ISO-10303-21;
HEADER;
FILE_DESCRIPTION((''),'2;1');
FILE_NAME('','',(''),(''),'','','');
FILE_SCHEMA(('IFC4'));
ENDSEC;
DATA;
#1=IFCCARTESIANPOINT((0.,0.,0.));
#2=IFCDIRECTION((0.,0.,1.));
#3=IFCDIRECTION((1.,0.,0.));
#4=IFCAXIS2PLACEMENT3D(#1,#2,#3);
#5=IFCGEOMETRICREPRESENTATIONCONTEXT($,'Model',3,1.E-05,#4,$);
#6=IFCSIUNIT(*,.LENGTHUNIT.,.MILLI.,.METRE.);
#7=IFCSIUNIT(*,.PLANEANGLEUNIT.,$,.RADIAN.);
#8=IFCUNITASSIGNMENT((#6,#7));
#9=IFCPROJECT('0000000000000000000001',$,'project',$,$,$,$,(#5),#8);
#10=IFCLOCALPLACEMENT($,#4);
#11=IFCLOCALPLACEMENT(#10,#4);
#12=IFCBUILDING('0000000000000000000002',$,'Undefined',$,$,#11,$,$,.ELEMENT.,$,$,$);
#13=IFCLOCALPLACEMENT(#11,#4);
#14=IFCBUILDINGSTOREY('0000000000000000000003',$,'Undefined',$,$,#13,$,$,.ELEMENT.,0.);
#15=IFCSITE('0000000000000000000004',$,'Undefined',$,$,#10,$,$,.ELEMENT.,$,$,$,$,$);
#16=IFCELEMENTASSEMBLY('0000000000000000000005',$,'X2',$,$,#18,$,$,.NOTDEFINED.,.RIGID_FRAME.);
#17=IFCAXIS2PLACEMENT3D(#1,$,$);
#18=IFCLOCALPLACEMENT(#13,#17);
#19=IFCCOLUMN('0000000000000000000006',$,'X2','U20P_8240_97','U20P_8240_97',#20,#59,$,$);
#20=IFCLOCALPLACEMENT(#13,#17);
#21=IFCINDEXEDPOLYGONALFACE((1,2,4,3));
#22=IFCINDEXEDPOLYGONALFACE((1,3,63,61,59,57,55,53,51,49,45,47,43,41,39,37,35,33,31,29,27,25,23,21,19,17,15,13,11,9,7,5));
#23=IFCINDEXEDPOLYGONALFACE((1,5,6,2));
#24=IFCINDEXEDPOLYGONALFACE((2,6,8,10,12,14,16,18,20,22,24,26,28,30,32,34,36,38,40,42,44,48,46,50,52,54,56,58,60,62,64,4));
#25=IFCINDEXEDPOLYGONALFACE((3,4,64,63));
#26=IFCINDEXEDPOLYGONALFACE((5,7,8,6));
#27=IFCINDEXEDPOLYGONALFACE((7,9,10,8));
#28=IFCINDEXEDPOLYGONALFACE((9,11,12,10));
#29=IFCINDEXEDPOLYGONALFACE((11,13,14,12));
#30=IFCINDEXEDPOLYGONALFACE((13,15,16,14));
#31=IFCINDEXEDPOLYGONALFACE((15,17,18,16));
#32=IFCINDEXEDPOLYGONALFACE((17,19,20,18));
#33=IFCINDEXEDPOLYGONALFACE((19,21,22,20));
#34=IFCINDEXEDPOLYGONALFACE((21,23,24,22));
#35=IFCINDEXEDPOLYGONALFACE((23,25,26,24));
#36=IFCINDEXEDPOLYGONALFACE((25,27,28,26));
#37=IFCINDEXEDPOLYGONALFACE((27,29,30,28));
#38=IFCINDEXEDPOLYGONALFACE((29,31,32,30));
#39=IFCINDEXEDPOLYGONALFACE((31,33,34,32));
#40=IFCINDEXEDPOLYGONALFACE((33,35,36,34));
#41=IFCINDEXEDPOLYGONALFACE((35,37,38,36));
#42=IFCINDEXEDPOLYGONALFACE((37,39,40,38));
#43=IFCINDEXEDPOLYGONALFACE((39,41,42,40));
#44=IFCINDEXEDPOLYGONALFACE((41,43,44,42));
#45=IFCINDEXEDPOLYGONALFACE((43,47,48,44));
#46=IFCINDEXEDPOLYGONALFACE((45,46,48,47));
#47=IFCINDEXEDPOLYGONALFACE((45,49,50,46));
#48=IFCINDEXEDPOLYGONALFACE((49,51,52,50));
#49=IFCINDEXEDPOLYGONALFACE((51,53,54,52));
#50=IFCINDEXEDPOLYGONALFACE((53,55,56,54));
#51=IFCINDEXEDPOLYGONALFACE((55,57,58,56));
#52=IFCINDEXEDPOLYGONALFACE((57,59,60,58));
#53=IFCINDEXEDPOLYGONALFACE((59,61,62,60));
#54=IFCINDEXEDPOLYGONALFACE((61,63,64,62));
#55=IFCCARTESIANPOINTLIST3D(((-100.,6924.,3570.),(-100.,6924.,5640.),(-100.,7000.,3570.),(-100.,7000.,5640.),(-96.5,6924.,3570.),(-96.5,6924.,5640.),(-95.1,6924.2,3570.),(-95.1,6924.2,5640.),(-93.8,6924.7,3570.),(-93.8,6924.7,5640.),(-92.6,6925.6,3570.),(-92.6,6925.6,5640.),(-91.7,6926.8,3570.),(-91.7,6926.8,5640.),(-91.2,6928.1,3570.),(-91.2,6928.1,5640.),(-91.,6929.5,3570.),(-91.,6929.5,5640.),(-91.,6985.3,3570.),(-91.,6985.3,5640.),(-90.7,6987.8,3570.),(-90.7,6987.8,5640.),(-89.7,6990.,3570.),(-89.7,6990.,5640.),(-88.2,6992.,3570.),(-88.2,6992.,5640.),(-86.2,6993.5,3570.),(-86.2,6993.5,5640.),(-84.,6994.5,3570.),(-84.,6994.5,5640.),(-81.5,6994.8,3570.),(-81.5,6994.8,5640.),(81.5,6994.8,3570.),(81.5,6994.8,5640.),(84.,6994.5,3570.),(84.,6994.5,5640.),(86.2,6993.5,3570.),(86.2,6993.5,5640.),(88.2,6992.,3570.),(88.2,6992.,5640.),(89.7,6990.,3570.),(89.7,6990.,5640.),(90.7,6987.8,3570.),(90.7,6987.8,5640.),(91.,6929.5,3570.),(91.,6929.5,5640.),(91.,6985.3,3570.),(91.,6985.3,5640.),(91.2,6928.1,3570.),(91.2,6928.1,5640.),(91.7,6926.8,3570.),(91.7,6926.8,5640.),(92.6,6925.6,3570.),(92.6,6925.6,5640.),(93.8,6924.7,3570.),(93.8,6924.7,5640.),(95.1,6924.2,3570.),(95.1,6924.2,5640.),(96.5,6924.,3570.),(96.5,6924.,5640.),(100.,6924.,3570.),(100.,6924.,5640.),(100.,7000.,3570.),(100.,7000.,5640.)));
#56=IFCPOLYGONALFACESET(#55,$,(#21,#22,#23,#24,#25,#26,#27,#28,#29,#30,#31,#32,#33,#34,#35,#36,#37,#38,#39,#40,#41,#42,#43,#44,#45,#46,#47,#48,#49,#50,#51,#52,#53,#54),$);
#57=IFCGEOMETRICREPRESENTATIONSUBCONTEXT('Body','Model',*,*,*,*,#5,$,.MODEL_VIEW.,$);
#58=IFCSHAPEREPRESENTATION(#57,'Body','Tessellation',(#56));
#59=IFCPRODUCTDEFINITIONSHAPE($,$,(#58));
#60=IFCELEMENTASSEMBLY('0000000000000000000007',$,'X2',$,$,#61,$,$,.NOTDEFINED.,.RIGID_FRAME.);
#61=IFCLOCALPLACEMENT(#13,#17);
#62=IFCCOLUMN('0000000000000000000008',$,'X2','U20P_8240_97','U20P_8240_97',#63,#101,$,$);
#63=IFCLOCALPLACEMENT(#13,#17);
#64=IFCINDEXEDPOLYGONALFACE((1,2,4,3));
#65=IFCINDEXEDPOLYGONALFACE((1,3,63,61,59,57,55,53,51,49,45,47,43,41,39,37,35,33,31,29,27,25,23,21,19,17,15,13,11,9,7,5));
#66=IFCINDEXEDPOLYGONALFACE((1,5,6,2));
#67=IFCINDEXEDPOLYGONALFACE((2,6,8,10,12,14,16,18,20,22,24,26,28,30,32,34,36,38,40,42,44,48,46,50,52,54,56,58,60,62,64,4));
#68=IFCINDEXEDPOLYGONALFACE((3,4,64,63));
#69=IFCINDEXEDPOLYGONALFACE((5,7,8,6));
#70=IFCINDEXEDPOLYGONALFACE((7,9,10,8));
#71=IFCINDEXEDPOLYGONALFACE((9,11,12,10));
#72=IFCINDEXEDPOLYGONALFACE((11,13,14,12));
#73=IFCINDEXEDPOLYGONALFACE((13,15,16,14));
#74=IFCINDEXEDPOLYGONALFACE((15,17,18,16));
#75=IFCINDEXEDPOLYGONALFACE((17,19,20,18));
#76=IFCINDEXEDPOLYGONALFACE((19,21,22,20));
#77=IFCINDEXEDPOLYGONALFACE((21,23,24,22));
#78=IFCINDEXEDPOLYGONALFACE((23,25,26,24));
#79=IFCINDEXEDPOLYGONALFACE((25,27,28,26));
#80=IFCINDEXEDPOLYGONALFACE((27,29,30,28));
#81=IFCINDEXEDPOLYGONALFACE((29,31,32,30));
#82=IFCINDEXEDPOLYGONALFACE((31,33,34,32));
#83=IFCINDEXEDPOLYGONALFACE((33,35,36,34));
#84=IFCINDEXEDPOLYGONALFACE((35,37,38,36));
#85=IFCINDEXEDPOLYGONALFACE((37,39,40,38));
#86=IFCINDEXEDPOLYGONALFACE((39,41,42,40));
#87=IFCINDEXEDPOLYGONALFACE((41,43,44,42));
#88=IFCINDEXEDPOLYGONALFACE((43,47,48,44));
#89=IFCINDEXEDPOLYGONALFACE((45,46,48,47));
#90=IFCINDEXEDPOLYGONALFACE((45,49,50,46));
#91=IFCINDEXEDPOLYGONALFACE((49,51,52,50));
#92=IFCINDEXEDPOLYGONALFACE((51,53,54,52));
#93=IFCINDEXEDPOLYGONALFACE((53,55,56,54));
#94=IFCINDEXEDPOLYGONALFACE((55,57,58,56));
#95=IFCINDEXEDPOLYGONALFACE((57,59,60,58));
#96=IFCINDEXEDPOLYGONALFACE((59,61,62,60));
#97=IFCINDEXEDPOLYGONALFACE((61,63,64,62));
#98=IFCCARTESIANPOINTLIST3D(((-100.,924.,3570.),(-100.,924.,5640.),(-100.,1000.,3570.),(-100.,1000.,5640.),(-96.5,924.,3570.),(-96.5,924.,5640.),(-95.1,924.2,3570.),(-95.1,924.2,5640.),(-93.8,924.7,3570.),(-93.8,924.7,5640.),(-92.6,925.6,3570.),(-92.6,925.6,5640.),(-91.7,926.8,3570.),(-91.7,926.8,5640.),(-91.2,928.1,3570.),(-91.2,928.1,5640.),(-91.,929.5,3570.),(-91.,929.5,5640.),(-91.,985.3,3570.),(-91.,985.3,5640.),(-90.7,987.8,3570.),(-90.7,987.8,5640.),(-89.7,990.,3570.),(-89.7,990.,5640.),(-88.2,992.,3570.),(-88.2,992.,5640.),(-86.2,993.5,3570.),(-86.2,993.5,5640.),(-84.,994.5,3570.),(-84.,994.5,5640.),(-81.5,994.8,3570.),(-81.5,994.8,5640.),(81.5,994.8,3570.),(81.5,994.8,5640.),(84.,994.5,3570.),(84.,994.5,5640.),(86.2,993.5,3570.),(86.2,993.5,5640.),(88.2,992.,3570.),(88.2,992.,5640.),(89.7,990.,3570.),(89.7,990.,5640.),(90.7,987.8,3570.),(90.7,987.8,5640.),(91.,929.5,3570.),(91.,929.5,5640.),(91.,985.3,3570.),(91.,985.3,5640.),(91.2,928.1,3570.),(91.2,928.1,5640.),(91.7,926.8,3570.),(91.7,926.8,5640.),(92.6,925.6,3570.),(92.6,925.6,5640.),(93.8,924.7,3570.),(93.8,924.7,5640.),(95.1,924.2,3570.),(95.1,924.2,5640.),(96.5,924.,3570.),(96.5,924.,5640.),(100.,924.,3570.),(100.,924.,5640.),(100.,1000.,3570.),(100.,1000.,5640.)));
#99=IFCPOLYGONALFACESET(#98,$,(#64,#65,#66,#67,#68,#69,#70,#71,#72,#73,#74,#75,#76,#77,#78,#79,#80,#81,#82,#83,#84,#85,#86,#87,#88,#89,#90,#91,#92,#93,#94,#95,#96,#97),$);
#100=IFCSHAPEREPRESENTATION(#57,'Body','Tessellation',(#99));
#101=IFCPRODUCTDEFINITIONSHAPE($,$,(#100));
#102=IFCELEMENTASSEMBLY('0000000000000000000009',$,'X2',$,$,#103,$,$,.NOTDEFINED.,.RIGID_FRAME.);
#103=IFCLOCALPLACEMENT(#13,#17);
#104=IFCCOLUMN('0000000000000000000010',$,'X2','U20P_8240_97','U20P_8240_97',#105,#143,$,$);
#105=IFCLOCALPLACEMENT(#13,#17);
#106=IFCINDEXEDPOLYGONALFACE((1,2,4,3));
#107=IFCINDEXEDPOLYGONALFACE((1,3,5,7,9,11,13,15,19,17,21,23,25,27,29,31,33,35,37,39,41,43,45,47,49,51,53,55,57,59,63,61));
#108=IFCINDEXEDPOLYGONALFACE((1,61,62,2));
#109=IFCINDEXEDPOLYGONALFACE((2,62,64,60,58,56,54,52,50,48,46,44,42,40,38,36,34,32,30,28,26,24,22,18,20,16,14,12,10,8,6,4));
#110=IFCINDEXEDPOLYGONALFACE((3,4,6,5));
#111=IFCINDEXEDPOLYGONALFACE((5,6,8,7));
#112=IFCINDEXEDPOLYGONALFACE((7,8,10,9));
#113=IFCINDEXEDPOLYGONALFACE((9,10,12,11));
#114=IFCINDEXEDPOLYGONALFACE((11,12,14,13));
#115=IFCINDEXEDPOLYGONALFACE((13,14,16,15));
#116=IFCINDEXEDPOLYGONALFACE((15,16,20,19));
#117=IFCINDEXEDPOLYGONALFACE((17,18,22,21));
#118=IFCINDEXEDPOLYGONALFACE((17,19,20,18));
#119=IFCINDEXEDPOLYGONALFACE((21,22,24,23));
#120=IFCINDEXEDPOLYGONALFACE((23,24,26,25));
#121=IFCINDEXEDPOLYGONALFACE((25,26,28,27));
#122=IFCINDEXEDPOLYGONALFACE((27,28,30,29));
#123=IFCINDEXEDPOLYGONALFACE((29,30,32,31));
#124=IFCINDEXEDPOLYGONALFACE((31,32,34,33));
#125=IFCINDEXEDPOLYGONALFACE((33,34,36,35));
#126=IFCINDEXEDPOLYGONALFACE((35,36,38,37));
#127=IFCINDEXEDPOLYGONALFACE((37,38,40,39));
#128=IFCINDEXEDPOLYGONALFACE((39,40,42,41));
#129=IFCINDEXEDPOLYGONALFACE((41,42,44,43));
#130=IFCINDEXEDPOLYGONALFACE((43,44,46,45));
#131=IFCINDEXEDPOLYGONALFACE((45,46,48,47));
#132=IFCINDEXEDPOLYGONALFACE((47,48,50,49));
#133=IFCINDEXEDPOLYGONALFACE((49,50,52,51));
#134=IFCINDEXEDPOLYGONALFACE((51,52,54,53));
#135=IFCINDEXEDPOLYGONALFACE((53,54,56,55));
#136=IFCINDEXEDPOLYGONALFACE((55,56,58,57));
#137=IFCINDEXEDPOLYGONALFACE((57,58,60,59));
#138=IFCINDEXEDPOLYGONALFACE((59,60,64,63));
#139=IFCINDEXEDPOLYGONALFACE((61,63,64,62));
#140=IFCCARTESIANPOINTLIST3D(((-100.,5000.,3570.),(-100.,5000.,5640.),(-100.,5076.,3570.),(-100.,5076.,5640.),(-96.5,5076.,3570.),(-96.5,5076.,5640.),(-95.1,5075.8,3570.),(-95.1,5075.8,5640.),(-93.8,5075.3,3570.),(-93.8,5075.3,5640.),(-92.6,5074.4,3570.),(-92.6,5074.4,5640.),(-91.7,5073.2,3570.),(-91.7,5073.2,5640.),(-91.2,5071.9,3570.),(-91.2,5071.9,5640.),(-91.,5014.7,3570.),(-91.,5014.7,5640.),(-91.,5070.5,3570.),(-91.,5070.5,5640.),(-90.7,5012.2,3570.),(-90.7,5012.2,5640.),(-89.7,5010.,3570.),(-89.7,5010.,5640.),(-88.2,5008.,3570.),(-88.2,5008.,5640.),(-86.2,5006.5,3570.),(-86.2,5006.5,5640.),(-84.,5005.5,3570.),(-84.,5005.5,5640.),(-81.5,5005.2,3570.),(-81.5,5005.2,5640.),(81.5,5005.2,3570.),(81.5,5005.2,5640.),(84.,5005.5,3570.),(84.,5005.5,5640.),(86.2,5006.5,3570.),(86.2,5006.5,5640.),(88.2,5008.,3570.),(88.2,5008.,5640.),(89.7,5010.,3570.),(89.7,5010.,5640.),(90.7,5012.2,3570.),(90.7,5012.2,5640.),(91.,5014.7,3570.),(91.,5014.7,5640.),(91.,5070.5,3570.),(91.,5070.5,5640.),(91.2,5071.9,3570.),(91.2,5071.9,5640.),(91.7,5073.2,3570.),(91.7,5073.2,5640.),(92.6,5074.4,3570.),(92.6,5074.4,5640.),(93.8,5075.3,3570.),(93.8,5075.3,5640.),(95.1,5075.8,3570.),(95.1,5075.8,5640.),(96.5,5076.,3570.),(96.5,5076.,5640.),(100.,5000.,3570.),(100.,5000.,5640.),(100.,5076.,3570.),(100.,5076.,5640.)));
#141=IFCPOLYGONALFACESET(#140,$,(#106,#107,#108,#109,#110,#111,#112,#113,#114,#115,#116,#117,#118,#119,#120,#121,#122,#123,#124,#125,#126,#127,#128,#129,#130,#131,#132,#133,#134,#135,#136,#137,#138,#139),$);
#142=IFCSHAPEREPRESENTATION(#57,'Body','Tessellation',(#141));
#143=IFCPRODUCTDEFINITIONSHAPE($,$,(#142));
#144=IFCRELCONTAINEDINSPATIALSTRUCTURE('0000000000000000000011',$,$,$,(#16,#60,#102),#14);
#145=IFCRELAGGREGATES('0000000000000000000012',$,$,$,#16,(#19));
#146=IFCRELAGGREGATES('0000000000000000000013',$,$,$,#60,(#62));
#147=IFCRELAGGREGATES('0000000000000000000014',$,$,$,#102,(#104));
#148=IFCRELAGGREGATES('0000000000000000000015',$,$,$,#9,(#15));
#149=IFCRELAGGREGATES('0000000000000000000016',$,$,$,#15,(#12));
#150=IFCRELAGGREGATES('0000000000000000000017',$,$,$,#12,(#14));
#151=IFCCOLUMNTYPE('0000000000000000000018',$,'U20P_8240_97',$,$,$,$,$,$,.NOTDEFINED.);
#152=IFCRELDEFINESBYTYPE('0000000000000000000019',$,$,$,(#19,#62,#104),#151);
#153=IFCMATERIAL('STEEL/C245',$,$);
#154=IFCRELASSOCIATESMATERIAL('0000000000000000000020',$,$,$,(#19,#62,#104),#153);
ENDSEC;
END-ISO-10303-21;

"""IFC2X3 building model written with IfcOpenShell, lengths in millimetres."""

from ifc_helpers import new_model, si_unit, frame, origin_with_axes, origin_2d_with_axis, place, context, subcontext, project, spatial, u_section, extrude, material, type_object, element, aggregate, save


model = new_model("IFC2X3")

# Units and contexts
model_context = context("Model", 3, precision=1e-05, world=origin_with_axes())
body_context = subcontext(model_context, "Body", "Model", "MODEL_VIEW")
ifc_project = project(units=[si_unit("LENGTHUNIT", "METRE", prefix="MILLI"), si_unit("PLANEANGLEUNIT", "RADIAN")], contexts=[model_context])

# Site, building, storey
site_placement = place(None, origin_with_axes())
site = spatial("IfcSite", under=ifc_project, at=site_placement, Name="Undefined", CompositionType="ELEMENT")
building_placement = place(site_placement, origin_with_axes())
building = spatial("IfcBuilding", under=site, at=building_placement, Name="Undefined", CompositionType="ELEMENT")
storey_placement = place(building_placement, origin_with_axes())
storey = spatial("IfcBuildingStorey", under=building, at=storey_placement, Name="Undefined", CompositionType="ELEMENT", Elevation=0.0)

# Element assemblies, columns
assembly_1_placement = place(storey_placement, origin_with_axes())
assembly_1 = element("IfcElementAssembly", 1, at=assembly_1_placement, inside=storey, Name="X2", AssemblyPlace="NOTDEFINED", PredefinedType="RIGID_FRAME")
ifc_material_1 = material(Name="STEEL/C245")
column_type = type_object("IfcColumnType", Name="U20P_8240_97", PredefinedType="NOTDEFINED")
column_1_placement = place(assembly_1_placement, frame((0.0, 6962.0, 3570.0), z_axis=(0.0, 0.0, 1.0), x_axis=(-1.0, 0.0, 0.0)))
column_1 = element("IfcColumn", 2, at=column_1_placement, type_object=column_type, material=ifc_material_1, Name="X2", Description="U20P_8240_97", ObjectType="U20P_8240_97", context=body_context, shape_type="SweptSolid", body=[
    extrude(u_section(Depth=200.0, FlangeWidth=76.0, WebThickness=5.2, FlangeThickness=9.0, FilletRadius=9.5, EdgeRadius=5.5, at=origin_2d_with_axis()), frame((0.0, 0.0, 2070.0), z_axis=(0.0, 0.0, -1.0), x_axis=(0.0, 1.0, 0.0)), (0.0, 0.0, 1.0), 2070.0),
])
aggregate(assembly_1, [column_1])
assembly_2_placement = place(storey_placement, origin_with_axes())
assembly_2 = element("IfcElementAssembly", 3, at=assembly_2_placement, inside=storey, Name="X2", AssemblyPlace="NOTDEFINED", PredefinedType="RIGID_FRAME")
column_2_placement = place(assembly_2_placement, frame((0.0, 962.0, 3570.0), z_axis=(0.0, 0.0, 1.0), x_axis=(-1.0, 0.0, 0.0)))
column_2 = element("IfcColumn", 4, at=column_2_placement, type_object=column_type, material=ifc_material_1, Name="X2", Description="U20P_8240_97", ObjectType="U20P_8240_97", context=body_context, shape_type="SweptSolid", body=[
    extrude(u_section(Depth=200.0, FlangeWidth=76.0, WebThickness=5.2, FlangeThickness=9.0, FilletRadius=9.5, EdgeRadius=5.5, at=origin_2d_with_axis()), frame((0.0, 0.0, 2070.0), z_axis=(0.0, 0.0, -1.0), x_axis=(0.0, 1.0, 0.0)), (0.0, 0.0, 1.0), 2070.0),
])
aggregate(assembly_2, [column_2])
assembly_3_placement = place(storey_placement, origin_with_axes())
assembly_3 = element("IfcElementAssembly", 5, at=assembly_3_placement, inside=storey, Name="X2", AssemblyPlace="NOTDEFINED", PredefinedType="RIGID_FRAME")
column_3_placement = place(assembly_3_placement, frame((0.0, 5038.0, 3570.0), z_axis=(0.0, 0.0, 1.0), x_axis=(1.0, 0.0, 0.0)))
column_3 = element("IfcColumn", 6, at=column_3_placement, type_object=column_type, material=ifc_material_1, Name="X2", Description="U20P_8240_97", ObjectType="U20P_8240_97", context=body_context, shape_type="SweptSolid", body=[
    extrude(u_section(Depth=200.0, FlangeWidth=76.0, WebThickness=5.2, FlangeThickness=9.0, FilletRadius=9.5, EdgeRadius=5.5, at=origin_2d_with_axis()), frame((0.0, 0.0, 2070.0), z_axis=(0.0, 0.0, -1.0), x_axis=(0.0, 1.0, 0.0)), (0.0, 0.0, 1.0), 2070.0),
])
aggregate(assembly_3, [column_3])

save(model, "model.ifc")
